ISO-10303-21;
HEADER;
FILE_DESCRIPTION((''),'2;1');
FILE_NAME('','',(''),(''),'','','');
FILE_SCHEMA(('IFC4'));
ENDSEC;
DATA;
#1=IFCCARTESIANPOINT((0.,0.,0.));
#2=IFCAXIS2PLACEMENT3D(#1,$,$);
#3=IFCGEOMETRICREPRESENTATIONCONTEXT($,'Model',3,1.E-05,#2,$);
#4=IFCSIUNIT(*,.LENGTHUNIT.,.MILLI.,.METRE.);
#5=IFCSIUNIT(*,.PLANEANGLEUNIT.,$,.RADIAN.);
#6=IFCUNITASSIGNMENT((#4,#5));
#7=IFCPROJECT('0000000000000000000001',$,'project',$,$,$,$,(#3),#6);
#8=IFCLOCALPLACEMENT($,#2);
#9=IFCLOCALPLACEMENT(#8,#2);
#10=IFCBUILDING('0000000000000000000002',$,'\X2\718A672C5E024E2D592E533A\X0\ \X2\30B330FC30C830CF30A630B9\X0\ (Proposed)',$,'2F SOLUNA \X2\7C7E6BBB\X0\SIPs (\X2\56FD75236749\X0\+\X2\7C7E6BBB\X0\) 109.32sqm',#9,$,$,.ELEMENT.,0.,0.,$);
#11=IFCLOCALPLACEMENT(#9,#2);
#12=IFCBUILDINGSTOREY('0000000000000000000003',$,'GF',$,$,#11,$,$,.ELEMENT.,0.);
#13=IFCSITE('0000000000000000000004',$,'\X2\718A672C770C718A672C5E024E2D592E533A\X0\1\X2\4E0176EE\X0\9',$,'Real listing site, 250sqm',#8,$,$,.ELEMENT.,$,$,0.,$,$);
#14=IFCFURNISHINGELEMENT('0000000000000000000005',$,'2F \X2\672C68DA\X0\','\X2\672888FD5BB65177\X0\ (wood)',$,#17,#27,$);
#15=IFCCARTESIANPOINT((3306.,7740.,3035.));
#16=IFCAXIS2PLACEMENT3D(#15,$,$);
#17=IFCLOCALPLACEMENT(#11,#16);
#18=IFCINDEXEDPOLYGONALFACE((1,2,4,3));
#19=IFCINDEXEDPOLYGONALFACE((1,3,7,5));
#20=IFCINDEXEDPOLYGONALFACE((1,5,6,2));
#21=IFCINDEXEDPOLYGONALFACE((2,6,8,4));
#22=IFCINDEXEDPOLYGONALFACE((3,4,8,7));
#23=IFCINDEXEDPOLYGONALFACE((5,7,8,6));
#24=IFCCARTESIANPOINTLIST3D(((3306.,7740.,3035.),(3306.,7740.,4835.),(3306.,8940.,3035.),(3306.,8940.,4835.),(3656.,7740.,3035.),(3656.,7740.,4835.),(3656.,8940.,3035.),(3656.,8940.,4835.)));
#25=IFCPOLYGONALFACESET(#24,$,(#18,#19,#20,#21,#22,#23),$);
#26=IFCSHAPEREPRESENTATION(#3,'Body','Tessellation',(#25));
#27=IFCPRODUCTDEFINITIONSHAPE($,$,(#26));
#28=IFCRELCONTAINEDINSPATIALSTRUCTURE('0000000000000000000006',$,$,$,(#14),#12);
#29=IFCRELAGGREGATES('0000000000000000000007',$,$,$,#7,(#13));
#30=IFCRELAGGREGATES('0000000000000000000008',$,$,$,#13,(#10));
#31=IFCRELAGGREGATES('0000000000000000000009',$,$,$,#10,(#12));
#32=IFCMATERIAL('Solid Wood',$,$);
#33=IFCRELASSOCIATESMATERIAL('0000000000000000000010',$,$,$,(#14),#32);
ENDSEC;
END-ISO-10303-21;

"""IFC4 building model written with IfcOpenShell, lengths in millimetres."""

from ifc_helpers import new_model, si_unit, frame, frame_2d, origin, place, context, project, spatial, rectangle, extrude, material, element, save


model = new_model("IFC4")

# Units and contexts
model_context = context("Model", 3, precision=1e-05, world=origin())
ifc_project = project(units=[si_unit("LENGTHUNIT", "METRE", prefix="MILLI"), si_unit("PLANEANGLEUNIT", "RADIAN")], contexts=[model_context])

# Site, building, storey
site_placement = place(None, origin())
site = spatial("IfcSite", under=ifc_project, at=site_placement, Name="熊本県熊本市中央区1丁目9", ObjectType="Real listing site, 250sqm", CompositionType="ELEMENT", RefElevation=0.0)
building_placement = place(site_placement, origin())
building = spatial("IfcBuilding", under=site, at=building_placement, Name="熊本市中央区 コートハウス (Proposed)", ObjectType="2F SOLUNA 籾殻SIPs (国産杉+籾殻) 109.32sqm", CompositionType="ELEMENT", ElevationOfRefHeight=0.0, ElevationOfTerrain=0.0)
storey_placement = place(building_placement, origin())
storey = spatial("IfcBuildingStorey", under=building, at=storey_placement, Name="GF", CompositionType="ELEMENT", Elevation=0.0)

# Shared definitions
ifc_material_1 = material(Name="Solid Wood")

# Furnishing element
furnishing_placement = place(storey_placement, frame((3306.0, 7740.0, 3035.0)))
element("IfcFurnishingElement", 1, at=furnishing_placement, inside=storey, material=ifc_material_1, Name="2F 本棚", Description="木製家具 (wood)", context=model_context, shape_type="SweptSolid", body=[
    extrude(rectangle(XDim=350.0, YDim=1200.0, at=frame_2d((175.0, 600.0))), frame((3306.0, 7740.0, 3035.0)), (0.0, 0.0, 1.0), 1800.0),
])

save(model, "model.ifc")
